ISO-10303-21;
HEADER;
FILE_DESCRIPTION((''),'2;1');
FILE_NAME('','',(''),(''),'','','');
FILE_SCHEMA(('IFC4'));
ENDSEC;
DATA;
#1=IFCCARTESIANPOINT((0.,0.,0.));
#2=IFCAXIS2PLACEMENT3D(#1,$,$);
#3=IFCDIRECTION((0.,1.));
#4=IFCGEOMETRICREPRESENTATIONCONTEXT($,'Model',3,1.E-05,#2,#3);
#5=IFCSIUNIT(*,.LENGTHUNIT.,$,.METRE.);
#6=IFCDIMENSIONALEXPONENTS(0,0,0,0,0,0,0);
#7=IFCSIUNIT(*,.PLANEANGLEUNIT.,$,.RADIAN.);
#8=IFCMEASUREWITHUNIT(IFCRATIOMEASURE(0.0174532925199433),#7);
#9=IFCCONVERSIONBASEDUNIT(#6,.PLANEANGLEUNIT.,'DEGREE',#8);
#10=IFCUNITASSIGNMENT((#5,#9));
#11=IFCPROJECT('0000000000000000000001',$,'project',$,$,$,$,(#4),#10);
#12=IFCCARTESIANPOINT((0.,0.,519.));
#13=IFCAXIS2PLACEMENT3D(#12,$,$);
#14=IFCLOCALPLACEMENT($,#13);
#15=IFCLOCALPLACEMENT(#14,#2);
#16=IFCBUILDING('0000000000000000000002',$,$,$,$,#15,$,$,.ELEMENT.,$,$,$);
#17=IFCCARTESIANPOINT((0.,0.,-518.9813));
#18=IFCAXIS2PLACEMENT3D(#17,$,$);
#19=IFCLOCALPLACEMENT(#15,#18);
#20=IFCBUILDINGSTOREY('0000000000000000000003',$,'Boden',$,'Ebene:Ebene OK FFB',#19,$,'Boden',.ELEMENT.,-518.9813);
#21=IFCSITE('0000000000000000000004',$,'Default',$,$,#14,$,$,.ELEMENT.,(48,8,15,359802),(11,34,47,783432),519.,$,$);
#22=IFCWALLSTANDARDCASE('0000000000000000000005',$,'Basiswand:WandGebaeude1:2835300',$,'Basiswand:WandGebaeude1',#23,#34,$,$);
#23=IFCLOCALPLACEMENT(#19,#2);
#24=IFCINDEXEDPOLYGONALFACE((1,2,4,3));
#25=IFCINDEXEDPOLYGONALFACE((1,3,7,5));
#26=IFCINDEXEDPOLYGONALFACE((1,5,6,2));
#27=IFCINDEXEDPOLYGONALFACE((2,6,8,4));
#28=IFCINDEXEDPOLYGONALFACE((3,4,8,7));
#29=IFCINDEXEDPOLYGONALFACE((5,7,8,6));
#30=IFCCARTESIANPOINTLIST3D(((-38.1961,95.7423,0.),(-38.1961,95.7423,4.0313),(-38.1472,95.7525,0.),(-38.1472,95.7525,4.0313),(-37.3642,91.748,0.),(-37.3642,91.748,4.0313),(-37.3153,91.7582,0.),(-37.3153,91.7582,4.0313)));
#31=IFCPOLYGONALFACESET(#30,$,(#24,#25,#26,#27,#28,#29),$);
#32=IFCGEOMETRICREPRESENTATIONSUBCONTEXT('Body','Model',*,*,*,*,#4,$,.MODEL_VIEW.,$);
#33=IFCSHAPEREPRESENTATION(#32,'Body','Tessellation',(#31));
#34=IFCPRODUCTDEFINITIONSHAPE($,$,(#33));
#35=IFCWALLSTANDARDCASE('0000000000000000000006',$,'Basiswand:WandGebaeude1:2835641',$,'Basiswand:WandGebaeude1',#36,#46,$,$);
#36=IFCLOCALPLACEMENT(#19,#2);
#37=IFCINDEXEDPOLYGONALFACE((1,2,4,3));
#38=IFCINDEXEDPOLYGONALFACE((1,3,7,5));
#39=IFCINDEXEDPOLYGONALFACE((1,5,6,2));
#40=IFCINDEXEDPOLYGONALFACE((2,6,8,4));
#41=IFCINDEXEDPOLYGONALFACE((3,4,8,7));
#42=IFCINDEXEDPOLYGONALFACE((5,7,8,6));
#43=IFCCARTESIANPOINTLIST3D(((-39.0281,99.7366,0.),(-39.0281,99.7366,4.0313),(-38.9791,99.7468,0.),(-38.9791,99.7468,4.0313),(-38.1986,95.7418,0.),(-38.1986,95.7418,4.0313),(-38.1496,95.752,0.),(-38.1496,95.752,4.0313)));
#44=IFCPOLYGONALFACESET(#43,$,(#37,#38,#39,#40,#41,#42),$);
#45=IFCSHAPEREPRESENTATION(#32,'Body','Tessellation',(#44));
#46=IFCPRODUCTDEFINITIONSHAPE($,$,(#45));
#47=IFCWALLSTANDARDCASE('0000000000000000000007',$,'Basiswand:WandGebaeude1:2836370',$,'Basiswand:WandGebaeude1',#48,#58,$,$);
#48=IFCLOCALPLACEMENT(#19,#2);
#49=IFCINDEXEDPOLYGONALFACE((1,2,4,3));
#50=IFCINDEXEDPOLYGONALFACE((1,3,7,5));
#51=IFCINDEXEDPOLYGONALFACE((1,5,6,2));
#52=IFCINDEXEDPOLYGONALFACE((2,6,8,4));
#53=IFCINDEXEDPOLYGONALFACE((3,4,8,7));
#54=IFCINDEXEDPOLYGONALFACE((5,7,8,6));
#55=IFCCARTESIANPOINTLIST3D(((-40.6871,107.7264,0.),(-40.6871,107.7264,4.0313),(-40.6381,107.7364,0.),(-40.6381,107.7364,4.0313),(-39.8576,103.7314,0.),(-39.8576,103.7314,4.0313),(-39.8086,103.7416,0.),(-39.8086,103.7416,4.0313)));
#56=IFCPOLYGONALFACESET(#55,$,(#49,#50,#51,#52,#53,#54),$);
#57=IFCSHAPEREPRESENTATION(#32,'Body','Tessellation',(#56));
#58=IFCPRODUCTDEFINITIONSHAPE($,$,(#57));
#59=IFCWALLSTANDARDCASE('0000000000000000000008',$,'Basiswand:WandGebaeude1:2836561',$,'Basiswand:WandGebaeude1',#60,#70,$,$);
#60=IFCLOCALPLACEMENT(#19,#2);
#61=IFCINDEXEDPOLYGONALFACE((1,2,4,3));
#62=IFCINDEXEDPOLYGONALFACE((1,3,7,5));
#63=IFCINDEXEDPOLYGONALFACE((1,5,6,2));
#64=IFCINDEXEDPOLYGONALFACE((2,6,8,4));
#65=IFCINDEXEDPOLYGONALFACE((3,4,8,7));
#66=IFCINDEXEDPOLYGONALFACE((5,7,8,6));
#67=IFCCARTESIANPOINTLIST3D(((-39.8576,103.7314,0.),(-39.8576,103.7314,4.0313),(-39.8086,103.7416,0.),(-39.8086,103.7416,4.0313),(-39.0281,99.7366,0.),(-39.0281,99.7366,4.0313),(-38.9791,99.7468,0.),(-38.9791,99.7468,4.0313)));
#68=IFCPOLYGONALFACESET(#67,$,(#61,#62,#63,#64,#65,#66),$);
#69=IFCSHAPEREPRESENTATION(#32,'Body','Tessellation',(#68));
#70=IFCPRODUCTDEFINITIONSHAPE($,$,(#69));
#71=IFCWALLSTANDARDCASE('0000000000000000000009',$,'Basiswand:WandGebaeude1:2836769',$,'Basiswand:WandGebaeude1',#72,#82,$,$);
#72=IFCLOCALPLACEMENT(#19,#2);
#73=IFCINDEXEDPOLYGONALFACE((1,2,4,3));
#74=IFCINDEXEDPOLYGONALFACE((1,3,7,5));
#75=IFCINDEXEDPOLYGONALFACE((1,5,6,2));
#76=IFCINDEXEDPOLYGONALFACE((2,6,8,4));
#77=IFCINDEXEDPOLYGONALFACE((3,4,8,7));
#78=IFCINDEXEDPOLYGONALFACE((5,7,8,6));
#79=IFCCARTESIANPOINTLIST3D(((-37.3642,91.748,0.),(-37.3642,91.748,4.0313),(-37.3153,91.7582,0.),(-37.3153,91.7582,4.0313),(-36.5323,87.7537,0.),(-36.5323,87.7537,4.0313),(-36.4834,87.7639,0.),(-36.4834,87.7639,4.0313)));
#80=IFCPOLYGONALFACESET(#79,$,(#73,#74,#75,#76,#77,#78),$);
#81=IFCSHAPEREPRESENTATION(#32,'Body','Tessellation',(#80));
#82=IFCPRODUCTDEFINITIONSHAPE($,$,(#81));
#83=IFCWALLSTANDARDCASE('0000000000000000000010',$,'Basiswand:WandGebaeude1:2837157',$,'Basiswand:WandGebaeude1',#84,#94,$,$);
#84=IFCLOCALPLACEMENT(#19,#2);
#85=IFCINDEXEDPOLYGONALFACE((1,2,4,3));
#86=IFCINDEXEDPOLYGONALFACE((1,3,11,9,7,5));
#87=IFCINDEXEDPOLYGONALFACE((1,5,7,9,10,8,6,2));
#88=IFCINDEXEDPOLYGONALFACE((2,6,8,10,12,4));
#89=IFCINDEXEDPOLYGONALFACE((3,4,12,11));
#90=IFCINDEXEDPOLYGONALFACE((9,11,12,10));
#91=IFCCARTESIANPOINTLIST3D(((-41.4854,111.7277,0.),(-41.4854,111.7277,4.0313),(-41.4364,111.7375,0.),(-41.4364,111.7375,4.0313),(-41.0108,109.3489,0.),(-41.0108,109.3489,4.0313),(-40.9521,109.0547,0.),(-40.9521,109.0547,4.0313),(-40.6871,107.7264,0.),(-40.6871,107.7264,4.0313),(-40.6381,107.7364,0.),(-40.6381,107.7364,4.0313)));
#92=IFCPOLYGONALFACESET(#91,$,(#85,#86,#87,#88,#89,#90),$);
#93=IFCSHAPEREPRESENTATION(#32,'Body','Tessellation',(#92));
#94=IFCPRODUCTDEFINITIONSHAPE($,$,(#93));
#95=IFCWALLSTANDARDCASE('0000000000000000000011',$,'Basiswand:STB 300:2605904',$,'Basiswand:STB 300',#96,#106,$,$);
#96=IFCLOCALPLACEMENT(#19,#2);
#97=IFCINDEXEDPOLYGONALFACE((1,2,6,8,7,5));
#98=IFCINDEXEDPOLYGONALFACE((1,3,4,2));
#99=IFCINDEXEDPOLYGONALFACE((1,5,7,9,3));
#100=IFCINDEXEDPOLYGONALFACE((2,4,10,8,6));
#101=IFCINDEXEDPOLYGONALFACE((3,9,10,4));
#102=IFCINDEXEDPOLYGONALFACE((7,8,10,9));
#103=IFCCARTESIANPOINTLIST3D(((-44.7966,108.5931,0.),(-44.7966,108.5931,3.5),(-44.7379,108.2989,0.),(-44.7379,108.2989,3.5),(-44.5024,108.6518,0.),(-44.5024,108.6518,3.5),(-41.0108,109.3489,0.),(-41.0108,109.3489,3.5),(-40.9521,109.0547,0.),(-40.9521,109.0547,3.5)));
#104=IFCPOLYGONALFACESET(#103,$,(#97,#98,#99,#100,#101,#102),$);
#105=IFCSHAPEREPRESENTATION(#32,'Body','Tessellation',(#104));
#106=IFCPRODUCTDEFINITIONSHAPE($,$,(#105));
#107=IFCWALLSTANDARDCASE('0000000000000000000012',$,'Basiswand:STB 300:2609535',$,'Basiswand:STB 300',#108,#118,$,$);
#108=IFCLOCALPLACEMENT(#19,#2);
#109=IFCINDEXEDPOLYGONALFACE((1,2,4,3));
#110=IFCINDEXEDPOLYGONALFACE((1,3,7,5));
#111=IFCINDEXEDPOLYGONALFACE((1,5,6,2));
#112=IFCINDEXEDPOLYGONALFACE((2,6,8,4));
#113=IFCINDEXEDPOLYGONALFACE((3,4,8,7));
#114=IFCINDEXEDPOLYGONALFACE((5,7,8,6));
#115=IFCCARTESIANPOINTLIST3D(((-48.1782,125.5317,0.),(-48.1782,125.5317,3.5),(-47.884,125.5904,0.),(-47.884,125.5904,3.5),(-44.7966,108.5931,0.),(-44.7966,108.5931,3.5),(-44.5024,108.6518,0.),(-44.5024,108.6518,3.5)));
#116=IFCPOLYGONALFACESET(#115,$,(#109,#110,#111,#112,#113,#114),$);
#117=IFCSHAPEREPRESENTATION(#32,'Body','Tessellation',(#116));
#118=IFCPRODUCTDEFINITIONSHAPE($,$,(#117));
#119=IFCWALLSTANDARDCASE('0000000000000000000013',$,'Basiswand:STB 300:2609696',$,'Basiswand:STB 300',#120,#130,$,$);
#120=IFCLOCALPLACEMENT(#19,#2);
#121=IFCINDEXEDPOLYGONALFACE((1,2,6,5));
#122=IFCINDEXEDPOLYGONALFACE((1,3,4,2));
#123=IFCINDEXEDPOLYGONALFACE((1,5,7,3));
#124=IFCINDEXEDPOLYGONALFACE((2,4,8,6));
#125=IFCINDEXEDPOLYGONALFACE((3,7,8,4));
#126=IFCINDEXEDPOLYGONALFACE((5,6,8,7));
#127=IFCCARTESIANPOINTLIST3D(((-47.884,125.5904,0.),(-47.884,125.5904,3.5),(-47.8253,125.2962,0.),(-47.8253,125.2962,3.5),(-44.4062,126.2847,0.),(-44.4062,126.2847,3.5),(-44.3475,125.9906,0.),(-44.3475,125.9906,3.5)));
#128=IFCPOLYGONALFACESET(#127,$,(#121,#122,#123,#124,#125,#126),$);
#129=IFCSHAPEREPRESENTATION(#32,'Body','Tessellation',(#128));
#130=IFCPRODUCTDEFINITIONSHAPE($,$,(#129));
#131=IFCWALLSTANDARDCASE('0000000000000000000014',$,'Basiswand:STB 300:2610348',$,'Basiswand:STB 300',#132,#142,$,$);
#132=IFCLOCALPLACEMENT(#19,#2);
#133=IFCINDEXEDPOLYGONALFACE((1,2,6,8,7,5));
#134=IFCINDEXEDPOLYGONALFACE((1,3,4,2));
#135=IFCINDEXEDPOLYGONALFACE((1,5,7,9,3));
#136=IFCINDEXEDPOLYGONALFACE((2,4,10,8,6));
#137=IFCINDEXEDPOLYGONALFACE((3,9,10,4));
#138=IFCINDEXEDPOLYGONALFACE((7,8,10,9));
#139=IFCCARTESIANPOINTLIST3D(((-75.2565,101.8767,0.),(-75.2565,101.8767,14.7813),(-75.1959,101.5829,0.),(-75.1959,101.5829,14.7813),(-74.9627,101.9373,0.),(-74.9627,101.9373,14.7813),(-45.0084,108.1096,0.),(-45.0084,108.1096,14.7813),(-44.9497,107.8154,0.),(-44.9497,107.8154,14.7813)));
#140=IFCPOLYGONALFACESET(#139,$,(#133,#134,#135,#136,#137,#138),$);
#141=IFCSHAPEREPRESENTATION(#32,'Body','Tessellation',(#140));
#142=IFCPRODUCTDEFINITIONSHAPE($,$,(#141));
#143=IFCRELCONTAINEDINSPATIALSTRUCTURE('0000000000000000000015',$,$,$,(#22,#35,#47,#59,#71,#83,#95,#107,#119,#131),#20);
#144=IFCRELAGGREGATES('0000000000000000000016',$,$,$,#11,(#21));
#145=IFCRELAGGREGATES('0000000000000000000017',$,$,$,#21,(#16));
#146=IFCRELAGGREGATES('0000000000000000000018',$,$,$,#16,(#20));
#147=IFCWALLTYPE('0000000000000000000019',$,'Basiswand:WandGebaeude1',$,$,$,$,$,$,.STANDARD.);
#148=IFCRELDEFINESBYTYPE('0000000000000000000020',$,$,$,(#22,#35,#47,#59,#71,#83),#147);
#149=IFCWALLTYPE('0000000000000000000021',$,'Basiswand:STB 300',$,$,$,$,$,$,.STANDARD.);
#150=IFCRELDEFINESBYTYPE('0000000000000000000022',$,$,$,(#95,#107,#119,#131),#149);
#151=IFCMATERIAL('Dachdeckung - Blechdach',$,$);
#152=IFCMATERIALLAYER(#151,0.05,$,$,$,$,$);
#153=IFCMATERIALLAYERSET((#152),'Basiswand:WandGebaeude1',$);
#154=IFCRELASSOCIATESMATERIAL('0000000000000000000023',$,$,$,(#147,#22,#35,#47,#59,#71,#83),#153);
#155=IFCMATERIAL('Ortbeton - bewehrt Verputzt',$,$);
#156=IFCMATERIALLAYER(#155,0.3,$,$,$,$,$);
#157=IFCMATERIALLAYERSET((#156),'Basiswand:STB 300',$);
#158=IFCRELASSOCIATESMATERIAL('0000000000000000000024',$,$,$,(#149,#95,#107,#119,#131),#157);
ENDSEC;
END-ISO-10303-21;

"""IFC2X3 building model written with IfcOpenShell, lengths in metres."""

from ifc_helpers import new_model, entity, si_unit, converted_unit, direction, frame, frame_2d, origin, place, context, subcontext, project, spatial, polyline, rectangle, outline, extrude, material, layer, layer_set, layer_usage, type_object, element, save


model = new_model("IFC2X3")

# Units and contexts
model_context = context("Model", 3, precision=1e-05, world=origin(), true_north=direction((0.0, 1.0)))
body_context = subcontext(model_context, "Body", "Model", "MODEL_VIEW")
ifc_project = project(units=[si_unit("LENGTHUNIT", "METRE"), converted_unit("PLANEANGLEUNIT", "DEGREE", entity("IfcRatioMeasure", 0.0174532925199433), si_unit("PLANEANGLEUNIT", "RADIAN"), dimensions=[0, 0, 0, 0, 0, 0, 0])], contexts=[model_context])

# Site, building, storey
site_placement = place(None, frame((0.0, 0.0, 519.0)))
site = spatial("IfcSite", under=ifc_project, at=site_placement, Name="Default", CompositionType="ELEMENT", RefLatitude=(48, 8, 15, 359802), RefLongitude=(11, 34, 47, 783432), RefElevation=519.0)
building_placement = place(site_placement, origin())
building = spatial("IfcBuilding", under=site, at=building_placement, CompositionType="ELEMENT")
storey_placement = place(building_placement, frame((0.0, 0.0, -518.9813)))
storey = spatial("IfcBuildingStorey", under=building, at=storey_placement, Name="Boden", ObjectType="Ebene:Ebene OK FFB", LongName="Boden", CompositionType="ELEMENT", Elevation=-518.9813)

# Shared definitions
ifc_material_1 = material(Name="Dachdeckung - Blechdach")
ifc_layer_1 = layer(ifc_material_1, 0.05)
ifc_layer_set_1 = layer_set([ifc_layer_1], Name="Basiswand:WandGebaeude1")
wall_type_1 = type_object("IfcWallType", Name="Basiswand:WandGebaeude1", PredefinedType="STANDARD", material=ifc_layer_set_1)

# Walls
ifc_layer_usage_1 = layer_usage(ifc_layer_set_1, "AXIS2", "NEGATIVE", 0.025)
wall_1_placement = place(storey_placement, frame((-37.3398, 91.7531, 0.0), z_axis=(0.0, 0.0, 1.0), x_axis=(-0.203899, 0.978992, 0.0)))
element("IfcWallStandardCase", 1, at=wall_1_placement, inside=storey, type_object=wall_type_1, material=ifc_layer_usage_1, Name="Basiswand:WandGebaeude1:2835300", ObjectType="Basiswand:WandGebaeude1", context=body_context, shape_type="SweptSolid", body=[
    extrude(rectangle(XDim=4.08, YDim=0.05, at=frame_2d((2.04, 0.0), x_axis=(-1.0, 0.0))), origin(), (0.0, 0.0, 1.0), 4.0313),
])
ifc_layer_usage_2 = layer_usage(ifc_layer_set_1, "AXIS2", "NEGATIVE", 0.025)
wall_2_placement = place(storey_placement, frame((-38.1741, 95.7469, 0.0), z_axis=(0.0, 0.0, 1.0), x_axis=(-0.203311, 0.979114, 0.0)))
element("IfcWallStandardCase", 2, at=wall_2_placement, inside=storey, type_object=wall_type_1, material=ifc_layer_usage_2, Name="Basiswand:WandGebaeude1:2835641", ObjectType="Basiswand:WandGebaeude1", context=body_context, shape_type="SweptSolid", body=[
    extrude(rectangle(XDim=4.08, YDim=0.05, at=frame_2d((2.04, 0.0), x_axis=(-1.0, 0.0))), origin(), (0.0, 0.0, 1.0), 4.0313),
])
ifc_layer_usage_3 = layer_usage(ifc_layer_set_1, "AXIS2", "NEGATIVE", 0.025)
wall_3_placement = place(storey_placement, frame((-39.8331, 103.7365, 0.0), z_axis=(0.0, 0.0, 1.0), x_axis=(-0.203311, 0.979114, 0.0)))
element("IfcWallStandardCase", 3, at=wall_3_placement, inside=storey, type_object=wall_type_1, material=ifc_layer_usage_3, Name="Basiswand:WandGebaeude1:2836370", ObjectType="Basiswand:WandGebaeude1", context=body_context, shape_type="SweptSolid", body=[
    extrude(outline(polyline([(4.08, -0.025), (4.0802, 0.025), (0.0, 0.025), (0.0, -0.025), (4.08, -0.025)])), origin(), (0.0, 0.0, 1.0), 4.0313),
])
ifc_layer_usage_4 = layer_usage(ifc_layer_set_1, "AXIS2", "NEGATIVE", 0.025)
wall_4_placement = place(storey_placement, frame((-39.0036, 99.7417, 0.0), z_axis=(0.0, 0.0, 1.0), x_axis=(-0.203311, 0.979114, 0.0)))
element("IfcWallStandardCase", 4, at=wall_4_placement, inside=storey, type_object=wall_type_1, material=ifc_layer_usage_4, Name="Basiswand:WandGebaeude1:2836561", ObjectType="Basiswand:WandGebaeude1", context=body_context, shape_type="SweptSolid", body=[
    extrude(rectangle(XDim=4.08, YDim=0.05, at=frame_2d((2.04, 0.0), x_axis=(-1.0, 0.0))), origin(), (0.0, 0.0, 1.0), 4.0313),
])
ifc_layer_usage_5 = layer_usage(ifc_layer_set_1, "AXIS2", "NEGATIVE", 0.025)
wall_5_placement = place(storey_placement, frame((-36.5079, 87.7588, 0.0), z_axis=(0.0, 0.0, 1.0), x_axis=(-0.203899, 0.978992, 0.0)))
element("IfcWallStandardCase", 5, at=wall_5_placement, inside=storey, type_object=wall_type_1, material=ifc_layer_usage_5, Name="Basiswand:WandGebaeude1:2836769", ObjectType="Basiswand:WandGebaeude1", context=body_context, shape_type="SweptSolid", body=[
    extrude(rectangle(XDim=4.08, YDim=0.05, at=frame_2d((2.04, 0.0), x_axis=(-1.0, 0.0))), origin(), (0.0, 0.0, 1.0), 4.0313),
])
ifc_layer_usage_6 = layer_usage(ifc_layer_set_1, "AXIS2", "NEGATIVE", 0.025)
wall_6_placement = place(storey_placement, frame((-40.6626, 107.7313, 0.0), z_axis=(0.0, 0.0, 1.0), x_axis=(-0.195647, 0.980674, 0.0)))
element("IfcWallStandardCase", 6, at=wall_6_placement, inside=storey, type_object=wall_type_1, material=ifc_layer_usage_6, Name="Basiswand:WandGebaeude1:2837157", ObjectType="Basiswand:WandGebaeude1", context=body_context, shape_type="SweptSolid", body=[
    extrude(outline(polyline([(4.0802, -0.025), (4.0802, 0.025), (1.6545, 0.025), (1.3545, 0.025), (0.0, 0.025), (0.0002, -0.025), (4.0802, -0.025)])), origin(), (0.0, 0.0, 1.0), 4.0313),
])
ifc_material_2 = material(Name="Ortbeton - bewehrt Verputzt")
ifc_layer_2 = layer(ifc_material_2, 0.3)
ifc_layer_set_2 = layer_set([ifc_layer_2], Name="Basiswand:STB 300")
ifc_layer_usage_7 = layer_usage(ifc_layer_set_2, "AXIS2", "NEGATIVE", 0.15)
wall_type_2 = type_object("IfcWallType", Name="Basiswand:STB 300", PredefinedType="STANDARD", material=ifc_layer_set_2)
wall_7_placement = place(storey_placement, frame((-40.9815, 109.2018, 0.0), z_axis=(0.0, 0.0, 1.0), x_axis=(-0.980648, -0.195778, 0.0)))
element("IfcWallStandardCase", 7, at=wall_7_placement, inside=storey, type_object=wall_type_2, material=ifc_layer_usage_7, Name="Basiswand:STB 300:2605904", ObjectType="Basiswand:STB 300", context=body_context, shape_type="SweptSolid", body=[
    extrude(outline(polyline([(3.8605, -0.15), (3.8605, 0.15), (0.0, 0.15), (0.0, -0.15), (3.5605, -0.15), (3.8605, -0.15)])), origin(), (0.0, 0.0, 1.0), 3.5),
])
ifc_layer_usage_8 = layer_usage(ifc_layer_set_2, "AXIS2", "NEGATIVE", 0.15)
wall_8_placement = place(storey_placement, frame((-44.6495, 108.6225, 0.0), z_axis=(0.0, 0.0, 1.0), x_axis=(-0.195778, 0.980648, 0.0)))
element("IfcWallStandardCase", 8, at=wall_8_placement, inside=storey, type_object=wall_type_2, material=ifc_layer_usage_8, Name="Basiswand:STB 300:2609535", ObjectType="Basiswand:STB 300", context=body_context, shape_type="SweptSolid", body=[
    extrude(rectangle(XDim=17.2728, YDim=0.3, at=frame_2d((8.6364, 0.0), x_axis=(-1.0, 0.0))), origin(), (0.0, 0.0, 1.0), 3.5),
])
ifc_layer_usage_9 = layer_usage(ifc_layer_set_2, "AXIS2", "NEGATIVE", 0.15)
wall_9_placement = place(storey_placement, frame((-47.8547, 125.4433, 0.0), z_axis=(0.0, 0.0, 1.0), x_axis=(0.980648, 0.195778, 0.0)))
element("IfcWallStandardCase", 9, at=wall_9_placement, inside=storey, type_object=wall_type_2, material=ifc_layer_usage_9, Name="Basiswand:STB 300:2609696", ObjectType="Basiswand:STB 300", context=body_context, shape_type="SweptSolid", body=[
    extrude(rectangle(XDim=3.5465, YDim=0.3, at=frame_2d((1.7732, 0.0), x_axis=(-1.0, 0.0))), origin(), (0.0, 0.0, 1.0), 3.5),
])
ifc_layer_usage_10 = layer_usage(ifc_layer_set_2, "AXIS2", "NEGATIVE", 0.15)
wall_10_placement = place(storey_placement, frame((-44.9781, 107.9627, 0.0), z_axis=(0.0, 0.0, 1.0), x_axis=(-0.979423, -0.201818, 0.0)))
element("IfcWallStandardCase", 10, at=wall_10_placement, inside=storey, type_object=wall_type_2, material=ifc_layer_usage_10, Name="Basiswand:STB 300:2610348", ObjectType="Basiswand:STB 300", context=body_context, shape_type="SweptSolid", body=[
    extrude(outline(polyline([(30.8836, -0.15), (30.8835, 0.15), (0.0019, 0.15), (0.0, -0.15), (30.5836, -0.15), (30.8836, -0.15)])), origin(), (0.0, 0.0, 1.0), 14.7813),
])

save(model, "model.ifc")
